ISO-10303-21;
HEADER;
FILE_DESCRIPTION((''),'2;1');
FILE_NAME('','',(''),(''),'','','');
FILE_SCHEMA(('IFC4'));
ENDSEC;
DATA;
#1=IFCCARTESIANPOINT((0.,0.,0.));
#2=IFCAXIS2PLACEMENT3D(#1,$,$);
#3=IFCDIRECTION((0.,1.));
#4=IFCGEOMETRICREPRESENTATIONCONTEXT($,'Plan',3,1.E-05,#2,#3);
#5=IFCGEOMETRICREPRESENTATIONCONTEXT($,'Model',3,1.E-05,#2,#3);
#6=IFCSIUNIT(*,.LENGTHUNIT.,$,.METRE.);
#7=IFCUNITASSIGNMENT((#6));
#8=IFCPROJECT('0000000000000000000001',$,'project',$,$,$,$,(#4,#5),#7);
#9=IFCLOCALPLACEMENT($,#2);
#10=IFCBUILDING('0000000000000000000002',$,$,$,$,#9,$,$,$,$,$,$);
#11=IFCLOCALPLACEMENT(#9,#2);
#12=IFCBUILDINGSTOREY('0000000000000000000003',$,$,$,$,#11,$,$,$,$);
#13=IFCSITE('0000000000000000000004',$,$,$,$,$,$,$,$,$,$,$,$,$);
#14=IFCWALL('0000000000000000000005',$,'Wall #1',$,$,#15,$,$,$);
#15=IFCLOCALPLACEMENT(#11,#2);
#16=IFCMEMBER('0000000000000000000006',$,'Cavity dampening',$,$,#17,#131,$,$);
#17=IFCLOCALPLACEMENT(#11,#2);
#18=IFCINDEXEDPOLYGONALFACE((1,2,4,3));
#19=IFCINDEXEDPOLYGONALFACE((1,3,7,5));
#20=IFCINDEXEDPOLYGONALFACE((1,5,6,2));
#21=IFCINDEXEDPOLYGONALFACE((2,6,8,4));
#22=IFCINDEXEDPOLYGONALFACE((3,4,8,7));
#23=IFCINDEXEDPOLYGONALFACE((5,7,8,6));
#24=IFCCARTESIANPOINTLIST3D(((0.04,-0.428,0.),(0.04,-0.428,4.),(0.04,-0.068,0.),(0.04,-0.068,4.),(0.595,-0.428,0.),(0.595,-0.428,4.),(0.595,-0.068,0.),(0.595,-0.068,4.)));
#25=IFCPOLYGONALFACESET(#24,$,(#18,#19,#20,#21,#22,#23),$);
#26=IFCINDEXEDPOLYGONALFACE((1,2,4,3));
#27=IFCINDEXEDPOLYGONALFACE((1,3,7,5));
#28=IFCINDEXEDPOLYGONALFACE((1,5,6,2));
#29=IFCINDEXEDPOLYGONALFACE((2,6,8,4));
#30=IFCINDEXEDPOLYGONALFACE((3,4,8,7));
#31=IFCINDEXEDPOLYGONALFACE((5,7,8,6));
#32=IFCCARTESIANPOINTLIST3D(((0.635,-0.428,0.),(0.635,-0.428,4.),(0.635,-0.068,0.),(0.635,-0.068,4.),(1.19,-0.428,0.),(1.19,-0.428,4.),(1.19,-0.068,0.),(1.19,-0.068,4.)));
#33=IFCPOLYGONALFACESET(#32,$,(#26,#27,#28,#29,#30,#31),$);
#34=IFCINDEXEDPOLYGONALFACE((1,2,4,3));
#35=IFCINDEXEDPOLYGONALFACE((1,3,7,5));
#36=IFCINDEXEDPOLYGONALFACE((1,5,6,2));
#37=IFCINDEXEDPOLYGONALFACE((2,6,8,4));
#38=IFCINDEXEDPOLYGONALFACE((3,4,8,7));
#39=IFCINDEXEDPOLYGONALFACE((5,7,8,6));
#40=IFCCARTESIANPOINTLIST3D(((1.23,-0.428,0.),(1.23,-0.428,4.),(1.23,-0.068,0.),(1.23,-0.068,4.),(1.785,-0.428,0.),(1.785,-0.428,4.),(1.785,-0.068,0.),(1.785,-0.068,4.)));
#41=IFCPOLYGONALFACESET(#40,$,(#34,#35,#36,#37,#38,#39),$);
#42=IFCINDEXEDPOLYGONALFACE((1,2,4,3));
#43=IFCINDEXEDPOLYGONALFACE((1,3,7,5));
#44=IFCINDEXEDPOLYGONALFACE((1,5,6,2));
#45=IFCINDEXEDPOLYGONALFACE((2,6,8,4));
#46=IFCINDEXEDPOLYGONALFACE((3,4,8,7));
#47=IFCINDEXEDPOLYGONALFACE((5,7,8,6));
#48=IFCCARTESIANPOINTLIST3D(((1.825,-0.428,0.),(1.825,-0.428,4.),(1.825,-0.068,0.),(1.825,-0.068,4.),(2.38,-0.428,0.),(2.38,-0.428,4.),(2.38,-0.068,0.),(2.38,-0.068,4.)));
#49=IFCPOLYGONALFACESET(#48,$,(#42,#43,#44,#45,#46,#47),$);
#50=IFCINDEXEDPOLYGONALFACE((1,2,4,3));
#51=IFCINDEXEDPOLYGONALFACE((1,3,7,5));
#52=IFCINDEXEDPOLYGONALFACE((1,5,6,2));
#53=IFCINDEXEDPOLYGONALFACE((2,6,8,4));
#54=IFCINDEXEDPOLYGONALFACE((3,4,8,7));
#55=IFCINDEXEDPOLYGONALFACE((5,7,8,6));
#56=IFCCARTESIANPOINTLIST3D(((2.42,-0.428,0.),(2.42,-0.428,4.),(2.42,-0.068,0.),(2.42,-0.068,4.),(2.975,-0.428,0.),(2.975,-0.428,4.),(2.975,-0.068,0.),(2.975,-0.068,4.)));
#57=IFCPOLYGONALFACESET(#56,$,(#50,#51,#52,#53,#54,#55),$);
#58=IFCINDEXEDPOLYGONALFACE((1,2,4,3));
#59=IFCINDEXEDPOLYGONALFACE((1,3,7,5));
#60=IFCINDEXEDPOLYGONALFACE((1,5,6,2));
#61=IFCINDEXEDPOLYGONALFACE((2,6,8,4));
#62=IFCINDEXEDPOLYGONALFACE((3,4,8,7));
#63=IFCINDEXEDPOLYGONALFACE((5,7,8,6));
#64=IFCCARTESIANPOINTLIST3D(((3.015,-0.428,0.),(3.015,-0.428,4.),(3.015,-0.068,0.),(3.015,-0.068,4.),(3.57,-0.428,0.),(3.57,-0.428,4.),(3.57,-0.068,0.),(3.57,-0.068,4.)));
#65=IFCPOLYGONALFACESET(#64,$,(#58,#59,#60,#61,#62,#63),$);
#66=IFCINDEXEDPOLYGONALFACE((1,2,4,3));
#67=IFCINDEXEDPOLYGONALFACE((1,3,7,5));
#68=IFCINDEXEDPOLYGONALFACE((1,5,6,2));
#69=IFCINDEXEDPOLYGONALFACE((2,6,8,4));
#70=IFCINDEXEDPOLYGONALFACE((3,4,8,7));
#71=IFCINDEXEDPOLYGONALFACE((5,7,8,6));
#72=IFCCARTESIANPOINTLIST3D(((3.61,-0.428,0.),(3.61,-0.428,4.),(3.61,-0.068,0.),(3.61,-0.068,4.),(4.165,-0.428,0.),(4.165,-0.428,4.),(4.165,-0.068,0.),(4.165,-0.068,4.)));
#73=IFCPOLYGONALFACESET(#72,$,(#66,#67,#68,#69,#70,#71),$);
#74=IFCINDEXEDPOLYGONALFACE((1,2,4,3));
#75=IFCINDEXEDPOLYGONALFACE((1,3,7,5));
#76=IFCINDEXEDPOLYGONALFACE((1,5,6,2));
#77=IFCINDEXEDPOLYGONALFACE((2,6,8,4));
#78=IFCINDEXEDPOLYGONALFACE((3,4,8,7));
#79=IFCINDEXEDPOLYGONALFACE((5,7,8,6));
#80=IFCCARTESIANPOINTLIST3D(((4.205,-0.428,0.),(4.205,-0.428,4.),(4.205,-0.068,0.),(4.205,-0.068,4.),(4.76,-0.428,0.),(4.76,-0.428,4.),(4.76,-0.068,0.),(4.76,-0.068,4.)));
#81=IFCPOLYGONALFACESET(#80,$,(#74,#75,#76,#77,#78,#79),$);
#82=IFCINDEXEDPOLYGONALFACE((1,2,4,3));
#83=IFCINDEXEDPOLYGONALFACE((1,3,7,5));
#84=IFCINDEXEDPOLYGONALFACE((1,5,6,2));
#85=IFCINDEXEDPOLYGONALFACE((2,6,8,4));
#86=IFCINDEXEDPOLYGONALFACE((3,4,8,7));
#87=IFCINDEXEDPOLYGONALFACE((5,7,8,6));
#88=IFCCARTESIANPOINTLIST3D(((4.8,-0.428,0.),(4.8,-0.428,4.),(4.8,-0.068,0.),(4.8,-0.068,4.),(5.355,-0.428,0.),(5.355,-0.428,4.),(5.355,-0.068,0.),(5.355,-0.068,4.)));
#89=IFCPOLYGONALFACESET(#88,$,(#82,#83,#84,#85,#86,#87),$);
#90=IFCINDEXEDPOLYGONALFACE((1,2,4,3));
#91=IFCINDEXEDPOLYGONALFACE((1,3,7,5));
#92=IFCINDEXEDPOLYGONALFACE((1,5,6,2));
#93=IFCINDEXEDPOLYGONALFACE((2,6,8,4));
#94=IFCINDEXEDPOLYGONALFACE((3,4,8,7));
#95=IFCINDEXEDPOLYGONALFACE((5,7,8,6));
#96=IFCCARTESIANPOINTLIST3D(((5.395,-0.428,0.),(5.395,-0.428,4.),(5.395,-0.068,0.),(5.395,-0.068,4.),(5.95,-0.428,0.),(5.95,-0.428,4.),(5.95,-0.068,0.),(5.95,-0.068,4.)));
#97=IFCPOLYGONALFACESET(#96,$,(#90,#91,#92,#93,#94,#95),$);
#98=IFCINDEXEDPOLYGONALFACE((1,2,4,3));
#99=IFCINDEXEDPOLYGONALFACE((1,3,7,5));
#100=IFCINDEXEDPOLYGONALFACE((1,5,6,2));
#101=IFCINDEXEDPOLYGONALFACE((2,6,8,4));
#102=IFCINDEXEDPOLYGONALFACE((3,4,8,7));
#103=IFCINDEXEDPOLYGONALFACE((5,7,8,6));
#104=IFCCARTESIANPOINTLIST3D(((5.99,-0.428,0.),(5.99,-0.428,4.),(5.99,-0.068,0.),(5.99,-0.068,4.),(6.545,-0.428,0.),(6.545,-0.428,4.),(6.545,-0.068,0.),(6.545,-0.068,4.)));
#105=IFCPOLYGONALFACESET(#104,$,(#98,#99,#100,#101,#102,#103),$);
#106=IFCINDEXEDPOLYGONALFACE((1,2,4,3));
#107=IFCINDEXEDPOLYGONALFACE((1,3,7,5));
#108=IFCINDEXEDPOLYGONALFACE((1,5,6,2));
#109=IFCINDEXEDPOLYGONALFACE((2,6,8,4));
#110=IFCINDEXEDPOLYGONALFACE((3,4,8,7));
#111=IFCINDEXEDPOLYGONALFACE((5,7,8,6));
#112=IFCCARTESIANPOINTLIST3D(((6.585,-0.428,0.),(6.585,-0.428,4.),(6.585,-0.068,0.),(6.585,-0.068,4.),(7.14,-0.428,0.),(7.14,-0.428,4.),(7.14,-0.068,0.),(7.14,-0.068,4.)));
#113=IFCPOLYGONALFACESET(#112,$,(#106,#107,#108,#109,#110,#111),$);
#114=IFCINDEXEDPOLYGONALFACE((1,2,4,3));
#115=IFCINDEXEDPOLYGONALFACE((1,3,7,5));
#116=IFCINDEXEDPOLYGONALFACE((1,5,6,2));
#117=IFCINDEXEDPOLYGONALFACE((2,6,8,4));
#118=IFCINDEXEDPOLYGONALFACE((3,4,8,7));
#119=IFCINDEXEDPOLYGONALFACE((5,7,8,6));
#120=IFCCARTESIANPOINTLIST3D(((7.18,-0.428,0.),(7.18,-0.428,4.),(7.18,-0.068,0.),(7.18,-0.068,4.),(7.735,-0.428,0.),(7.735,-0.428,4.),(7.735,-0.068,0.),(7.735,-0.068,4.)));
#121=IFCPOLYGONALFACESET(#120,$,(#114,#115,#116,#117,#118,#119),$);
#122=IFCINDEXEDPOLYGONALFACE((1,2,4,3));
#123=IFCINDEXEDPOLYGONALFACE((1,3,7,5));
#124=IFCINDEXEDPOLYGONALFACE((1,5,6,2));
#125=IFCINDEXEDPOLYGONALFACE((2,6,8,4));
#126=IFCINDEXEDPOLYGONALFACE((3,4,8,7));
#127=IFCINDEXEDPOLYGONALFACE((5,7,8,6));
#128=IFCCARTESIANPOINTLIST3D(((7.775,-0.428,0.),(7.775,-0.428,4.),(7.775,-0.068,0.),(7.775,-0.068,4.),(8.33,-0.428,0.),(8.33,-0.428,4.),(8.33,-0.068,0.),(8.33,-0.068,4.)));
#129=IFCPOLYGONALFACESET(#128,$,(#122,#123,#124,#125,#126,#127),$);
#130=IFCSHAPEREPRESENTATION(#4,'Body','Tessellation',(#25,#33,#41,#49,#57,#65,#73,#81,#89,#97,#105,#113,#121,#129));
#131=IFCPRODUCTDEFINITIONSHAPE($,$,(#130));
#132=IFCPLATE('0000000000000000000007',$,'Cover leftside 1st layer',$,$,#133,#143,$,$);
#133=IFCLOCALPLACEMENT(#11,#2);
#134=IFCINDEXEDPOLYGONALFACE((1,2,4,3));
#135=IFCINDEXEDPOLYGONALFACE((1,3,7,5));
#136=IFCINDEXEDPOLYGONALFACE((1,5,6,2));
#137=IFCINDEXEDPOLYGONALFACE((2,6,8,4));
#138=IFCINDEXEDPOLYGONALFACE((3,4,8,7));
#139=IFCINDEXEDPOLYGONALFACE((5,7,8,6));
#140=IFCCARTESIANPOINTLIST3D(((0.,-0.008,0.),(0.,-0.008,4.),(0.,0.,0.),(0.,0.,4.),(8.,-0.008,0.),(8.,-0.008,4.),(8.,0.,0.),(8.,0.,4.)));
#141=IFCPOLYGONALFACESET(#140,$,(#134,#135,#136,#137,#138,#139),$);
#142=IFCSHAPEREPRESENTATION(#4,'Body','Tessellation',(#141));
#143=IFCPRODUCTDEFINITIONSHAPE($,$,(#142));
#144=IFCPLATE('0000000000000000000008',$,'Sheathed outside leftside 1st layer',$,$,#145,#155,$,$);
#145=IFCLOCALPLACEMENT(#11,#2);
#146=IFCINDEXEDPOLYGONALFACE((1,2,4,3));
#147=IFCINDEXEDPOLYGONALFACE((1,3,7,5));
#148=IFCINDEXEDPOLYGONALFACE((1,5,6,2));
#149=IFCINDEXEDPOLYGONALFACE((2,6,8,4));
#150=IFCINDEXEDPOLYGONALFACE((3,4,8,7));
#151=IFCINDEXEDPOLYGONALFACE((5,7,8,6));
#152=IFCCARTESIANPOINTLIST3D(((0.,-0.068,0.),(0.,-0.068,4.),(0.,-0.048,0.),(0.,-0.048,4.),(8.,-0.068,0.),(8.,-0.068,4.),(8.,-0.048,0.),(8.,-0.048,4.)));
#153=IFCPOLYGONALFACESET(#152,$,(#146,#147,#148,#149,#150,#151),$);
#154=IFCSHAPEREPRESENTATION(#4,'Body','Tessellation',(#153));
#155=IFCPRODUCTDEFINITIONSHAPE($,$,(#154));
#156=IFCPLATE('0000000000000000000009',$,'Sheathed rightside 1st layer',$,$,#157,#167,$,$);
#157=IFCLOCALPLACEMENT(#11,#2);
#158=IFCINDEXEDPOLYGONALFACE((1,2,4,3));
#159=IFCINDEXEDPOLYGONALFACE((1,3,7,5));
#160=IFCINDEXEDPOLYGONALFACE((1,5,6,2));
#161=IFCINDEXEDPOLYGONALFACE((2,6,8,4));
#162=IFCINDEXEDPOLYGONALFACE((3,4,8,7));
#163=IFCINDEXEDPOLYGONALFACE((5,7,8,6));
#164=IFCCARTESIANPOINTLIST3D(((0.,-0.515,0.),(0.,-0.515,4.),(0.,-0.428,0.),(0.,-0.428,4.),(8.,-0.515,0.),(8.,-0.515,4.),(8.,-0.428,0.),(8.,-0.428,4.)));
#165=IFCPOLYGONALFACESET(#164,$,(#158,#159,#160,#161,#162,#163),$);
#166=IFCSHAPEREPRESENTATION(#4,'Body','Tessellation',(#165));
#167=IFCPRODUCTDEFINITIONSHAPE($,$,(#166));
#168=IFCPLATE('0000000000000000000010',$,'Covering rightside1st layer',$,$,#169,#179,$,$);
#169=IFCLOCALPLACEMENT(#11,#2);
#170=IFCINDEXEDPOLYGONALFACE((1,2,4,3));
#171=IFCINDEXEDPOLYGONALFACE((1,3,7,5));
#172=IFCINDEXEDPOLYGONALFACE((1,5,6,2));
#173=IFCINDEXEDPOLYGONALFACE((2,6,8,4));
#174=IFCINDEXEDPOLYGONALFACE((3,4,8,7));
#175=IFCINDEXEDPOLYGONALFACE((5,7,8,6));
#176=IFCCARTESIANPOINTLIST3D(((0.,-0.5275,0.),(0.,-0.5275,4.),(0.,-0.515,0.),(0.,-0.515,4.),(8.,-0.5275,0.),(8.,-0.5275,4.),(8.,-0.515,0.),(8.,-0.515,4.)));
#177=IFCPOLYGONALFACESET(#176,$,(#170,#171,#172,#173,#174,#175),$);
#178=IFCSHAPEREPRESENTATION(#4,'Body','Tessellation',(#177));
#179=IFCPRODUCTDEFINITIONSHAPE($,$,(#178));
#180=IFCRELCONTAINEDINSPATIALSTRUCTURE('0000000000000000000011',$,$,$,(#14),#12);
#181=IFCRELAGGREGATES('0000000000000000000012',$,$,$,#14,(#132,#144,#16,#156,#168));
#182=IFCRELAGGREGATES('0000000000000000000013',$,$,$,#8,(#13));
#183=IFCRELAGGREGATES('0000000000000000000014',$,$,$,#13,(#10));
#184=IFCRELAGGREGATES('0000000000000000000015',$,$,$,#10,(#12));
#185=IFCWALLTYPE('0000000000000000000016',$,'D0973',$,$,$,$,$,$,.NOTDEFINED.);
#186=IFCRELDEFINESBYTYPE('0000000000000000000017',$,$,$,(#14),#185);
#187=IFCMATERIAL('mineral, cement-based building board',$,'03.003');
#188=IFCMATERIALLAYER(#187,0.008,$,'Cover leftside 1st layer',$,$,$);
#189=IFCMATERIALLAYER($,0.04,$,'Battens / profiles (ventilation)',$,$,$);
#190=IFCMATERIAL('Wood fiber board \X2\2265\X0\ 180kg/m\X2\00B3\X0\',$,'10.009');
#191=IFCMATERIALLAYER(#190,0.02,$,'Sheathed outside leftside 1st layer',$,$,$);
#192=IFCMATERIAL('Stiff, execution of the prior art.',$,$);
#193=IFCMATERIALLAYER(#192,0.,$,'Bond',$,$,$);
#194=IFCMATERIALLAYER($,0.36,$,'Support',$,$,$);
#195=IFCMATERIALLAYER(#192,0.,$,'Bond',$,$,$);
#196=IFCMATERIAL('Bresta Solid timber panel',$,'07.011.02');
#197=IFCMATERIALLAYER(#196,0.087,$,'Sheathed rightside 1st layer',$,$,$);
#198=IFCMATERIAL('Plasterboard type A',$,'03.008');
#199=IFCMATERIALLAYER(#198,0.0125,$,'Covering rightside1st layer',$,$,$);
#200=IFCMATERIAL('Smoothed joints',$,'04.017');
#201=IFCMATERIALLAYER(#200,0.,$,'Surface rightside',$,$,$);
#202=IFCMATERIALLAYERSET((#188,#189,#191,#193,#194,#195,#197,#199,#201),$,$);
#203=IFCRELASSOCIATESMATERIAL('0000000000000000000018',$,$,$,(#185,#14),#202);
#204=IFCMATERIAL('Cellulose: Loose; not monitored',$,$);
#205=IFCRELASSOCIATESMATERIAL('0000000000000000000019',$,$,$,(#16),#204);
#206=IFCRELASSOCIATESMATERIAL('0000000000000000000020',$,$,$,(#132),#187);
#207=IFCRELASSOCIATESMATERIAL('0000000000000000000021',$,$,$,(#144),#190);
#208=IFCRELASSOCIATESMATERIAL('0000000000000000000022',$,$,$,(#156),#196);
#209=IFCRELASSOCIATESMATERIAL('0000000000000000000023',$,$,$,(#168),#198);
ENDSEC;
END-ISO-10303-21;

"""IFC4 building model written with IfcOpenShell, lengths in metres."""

from ifc_helpers import new_model, si_unit, direction, frame, frame_2d, origin, origin_with_axes, place, context, project, spatial, rectangle, extrude, material, layer, layer_set, type_object, element, aggregate, save


model = new_model("IFC4")

# Units and contexts
plan_context = context("Plan", 3, precision=1e-05, world=origin(), true_north=direction((0.0, 1.0)))
model_context = context("Model", 3, precision=1e-05, world=origin(), true_north=direction((0.0, 1.0)))
ifc_project = project(units=[si_unit("LENGTHUNIT", "METRE")], contexts=[plan_context, model_context])

# Site, building, storey
site = spatial("IfcSite", under=ifc_project)
building_placement = place(None, origin())
building = spatial("IfcBuilding", under=site, at=building_placement)
storey_placement = place(building_placement, origin())
storey = spatial("IfcBuildingStorey", under=building, at=storey_placement)

# Wall, member, plates
ifc_material_1 = material(Name="mineral, cement-based building board", Category="03.003")
ifc_layer_1 = layer(ifc_material_1, 0.008, Name="Cover leftside 1st layer")
ifc_layer_2 = layer(None, 0.04, Name="Battens / profiles (ventilation)")
ifc_material_2 = material(Name="Wood fiber board ≥ 180kg/m³", Category="10.009")
ifc_layer_3 = layer(ifc_material_2, 0.02, Name="Sheathed outside leftside 1st layer")
ifc_material_3 = material(Name="Stiff, execution of the prior art.")
ifc_layer_4 = layer(ifc_material_3, 0.0, Name="Bond")
ifc_layer_5 = layer(None, 0.36, Name="Support")
ifc_layer_6 = layer(ifc_material_3, 0.0, Name="Bond")
ifc_material_4 = material(Name="Bresta Solid timber panel", Category="07.011.02")
ifc_layer_7 = layer(ifc_material_4, 0.087, Name="Sheathed rightside 1st layer")
ifc_material_5 = material(Name="Plasterboard type A", Category="03.008")
ifc_layer_8 = layer(ifc_material_5, 0.0125, Name="Covering rightside1st layer")
ifc_material_6 = material(Name="Smoothed joints", Category="04.017")
ifc_layer_9 = layer(ifc_material_6, 0.0, Name="Surface rightside")
ifc_layer_set = layer_set([ifc_layer_1, ifc_layer_2, ifc_layer_3, ifc_layer_4, ifc_layer_5, ifc_layer_6, ifc_layer_7, ifc_layer_8, ifc_layer_9])
wall_type = type_object("IfcWallType", Name="D0973", PredefinedType="NOTDEFINED", material=ifc_layer_set)
wall_placement = place(None, frame((0.0, 0.0, 0.0), z_axis=(0.0, -1.0, 0.0), x_axis=(1.0, 0.0, 0.0)))
wall = element("IfcWall", 1, at=wall_placement, inside=storey, type_object=wall_type, material=ifc_layer_set, Name="Wall #1")
ifc_material_7 = material(Name="Cellulose: Loose; not monitored")
member_1_placement = place(wall_placement, origin())
member_1 = element("IfcMember", 2, at=member_1_placement, material=ifc_material_7, Name="Cavity dampening", context=plan_context, shape_type="SweptSolid", body=[
    extrude(rectangle(XDim=0.555, YDim=0.36, at=frame_2d((0.2775, 0.18), x_axis=(1.0, 0.0))), frame((0.04, 4.0, 0.068), z_axis=(0.0, -1.0, 0.0), x_axis=(1.0, 0.0, 0.0)), (0.0, 0.0, 1.0), 4.0),
    extrude(rectangle(XDim=0.555, YDim=0.36, at=frame_2d((0.2775, 0.18), x_axis=(1.0, 0.0))), frame((0.635, 4.0, 0.068), z_axis=(0.0, -1.0, 0.0), x_axis=(1.0, 0.0, 0.0)), (0.0, 0.0, 1.0), 4.0),
    extrude(rectangle(XDim=0.555, YDim=0.36, at=frame_2d((0.2775, 0.18), x_axis=(1.0, 0.0))), frame((1.23, 4.0, 0.068), z_axis=(0.0, -1.0, 0.0), x_axis=(1.0, 0.0, 0.0)), (0.0, 0.0, 1.0), 4.0),
    extrude(rectangle(XDim=0.555, YDim=0.36, at=frame_2d((0.2775, 0.18), x_axis=(1.0, 0.0))), frame((1.825, 4.0, 0.068), z_axis=(0.0, -1.0, 0.0), x_axis=(1.0, 0.0, 0.0)), (0.0, 0.0, 1.0), 4.0),
    extrude(rectangle(XDim=0.555, YDim=0.36, at=frame_2d((0.2775, 0.18), x_axis=(1.0, 0.0))), frame((2.42, 4.0, 0.068), z_axis=(0.0, -1.0, 0.0), x_axis=(1.0, 0.0, 0.0)), (0.0, 0.0, 1.0), 4.0),
    extrude(rectangle(XDim=0.555, YDim=0.36, at=frame_2d((0.2775, 0.18), x_axis=(1.0, 0.0))), frame((3.015, 4.0, 0.068), z_axis=(0.0, -1.0, 0.0), x_axis=(1.0, 0.0, 0.0)), (0.0, 0.0, 1.0), 4.0),
    extrude(rectangle(XDim=0.555, YDim=0.36, at=frame_2d((0.2775, 0.18), x_axis=(1.0, 0.0))), frame((3.61, 4.0, 0.068), z_axis=(0.0, -1.0, 0.0), x_axis=(1.0, 0.0, 0.0)), (0.0, 0.0, 1.0), 4.0),
    extrude(rectangle(XDim=0.555, YDim=0.36, at=frame_2d((0.2775, 0.18), x_axis=(1.0, 0.0))), frame((4.205, 4.0, 0.068), z_axis=(0.0, -1.0, 0.0), x_axis=(1.0, 0.0, 0.0)), (0.0, 0.0, 1.0), 4.0),
    extrude(rectangle(XDim=0.555, YDim=0.36, at=frame_2d((0.2775, 0.18), x_axis=(1.0, 0.0))), frame((4.8, 4.0, 0.068), z_axis=(0.0, -1.0, 0.0), x_axis=(1.0, 0.0, 0.0)), (0.0, 0.0, 1.0), 4.0),
    extrude(rectangle(XDim=0.555, YDim=0.36, at=frame_2d((0.2775, 0.18), x_axis=(1.0, 0.0))), frame((5.395, 4.0, 0.068), z_axis=(0.0, -1.0, 0.0), x_axis=(1.0, 0.0, 0.0)), (0.0, 0.0, 1.0), 4.0),
    extrude(rectangle(XDim=0.555, YDim=0.36, at=frame_2d((0.2775, 0.18), x_axis=(1.0, 0.0))), frame((5.99, 4.0, 0.068), z_axis=(0.0, -1.0, 0.0), x_axis=(1.0, 0.0, 0.0)), (0.0, 0.0, 1.0), 4.0),
    extrude(rectangle(XDim=0.555, YDim=0.36, at=frame_2d((0.2775, 0.18), x_axis=(1.0, 0.0))), frame((6.585, 4.0, 0.068), z_axis=(0.0, -1.0, 0.0), x_axis=(1.0, 0.0, 0.0)), (0.0, 0.0, 1.0), 4.0),
    extrude(rectangle(XDim=0.555, YDim=0.36, at=frame_2d((0.2775, 0.18), x_axis=(1.0, 0.0))), frame((7.18, 4.0, 0.068), z_axis=(0.0, -1.0, 0.0), x_axis=(1.0, 0.0, 0.0)), (0.0, 0.0, 1.0), 4.0),
    extrude(rectangle(XDim=0.555, YDim=0.36, at=frame_2d((0.2775, 0.18), x_axis=(1.0, 0.0))), frame((7.775, 4.0, 0.068), z_axis=(0.0, -1.0, 0.0), x_axis=(1.0, 0.0, 0.0)), (0.0, 0.0, 1.0), 4.0),
])
plate_1_placement = place(wall_placement, origin())
plate_1 = element("IfcPlate", 3, at=plate_1_placement, material=ifc_material_1, Name="Cover leftside 1st layer", context=plan_context, shape_type="SweptSolid", body=[
    extrude(rectangle(XDim=8.0, YDim=4.0, at=frame_2d((4.0, 2.0), x_axis=(1.0, 0.0))), origin_with_axes(), (0.0, 0.0, 1.0), 0.008),
])
plate_2_placement = place(wall_placement, origin())
plate_2 = element("IfcPlate", 4, at=plate_2_placement, material=ifc_material_2, Name="Sheathed outside leftside 1st layer", context=plan_context, shape_type="SweptSolid", body=[
    extrude(rectangle(XDim=8.0, YDim=4.0, at=frame_2d((4.0, 2.0), x_axis=(1.0, 0.0))), frame((0.0, 0.0, 0.048), z_axis=(0.0, 0.0, 1.0), x_axis=(1.0, 0.0, 0.0)), (0.0, 0.0, 1.0), 0.02),
])
plate_3_placement = place(wall_placement, origin())
plate_3 = element("IfcPlate", 5, at=plate_3_placement, material=ifc_material_4, Name="Sheathed rightside 1st layer", context=plan_context, shape_type="SweptSolid", body=[
    extrude(rectangle(XDim=8.0, YDim=4.0, at=frame_2d((4.0, 2.0), x_axis=(1.0, 0.0))), frame((0.0, 0.0, 0.428), z_axis=(0.0, 0.0, 1.0), x_axis=(1.0, 0.0, 0.0)), (0.0, 0.0, 1.0), 0.087),
])
plate_4_placement = place(wall_placement, origin())
plate_4 = element("IfcPlate", 6, at=plate_4_placement, material=ifc_material_5, Name="Covering rightside1st layer", context=plan_context, shape_type="SweptSolid", body=[
    extrude(rectangle(XDim=8.0, YDim=4.0, at=frame_2d((4.0, 2.0), x_axis=(1.0, 0.0))), frame((0.0, 0.0, 0.515), z_axis=(0.0, 0.0, 1.0), x_axis=(1.0, 0.0, 0.0)), (0.0, 0.0, 1.0), 0.0125),
])
aggregate(wall, [plate_1, plate_2, member_1, plate_3, plate_4])

save(model, "model.ifc")
